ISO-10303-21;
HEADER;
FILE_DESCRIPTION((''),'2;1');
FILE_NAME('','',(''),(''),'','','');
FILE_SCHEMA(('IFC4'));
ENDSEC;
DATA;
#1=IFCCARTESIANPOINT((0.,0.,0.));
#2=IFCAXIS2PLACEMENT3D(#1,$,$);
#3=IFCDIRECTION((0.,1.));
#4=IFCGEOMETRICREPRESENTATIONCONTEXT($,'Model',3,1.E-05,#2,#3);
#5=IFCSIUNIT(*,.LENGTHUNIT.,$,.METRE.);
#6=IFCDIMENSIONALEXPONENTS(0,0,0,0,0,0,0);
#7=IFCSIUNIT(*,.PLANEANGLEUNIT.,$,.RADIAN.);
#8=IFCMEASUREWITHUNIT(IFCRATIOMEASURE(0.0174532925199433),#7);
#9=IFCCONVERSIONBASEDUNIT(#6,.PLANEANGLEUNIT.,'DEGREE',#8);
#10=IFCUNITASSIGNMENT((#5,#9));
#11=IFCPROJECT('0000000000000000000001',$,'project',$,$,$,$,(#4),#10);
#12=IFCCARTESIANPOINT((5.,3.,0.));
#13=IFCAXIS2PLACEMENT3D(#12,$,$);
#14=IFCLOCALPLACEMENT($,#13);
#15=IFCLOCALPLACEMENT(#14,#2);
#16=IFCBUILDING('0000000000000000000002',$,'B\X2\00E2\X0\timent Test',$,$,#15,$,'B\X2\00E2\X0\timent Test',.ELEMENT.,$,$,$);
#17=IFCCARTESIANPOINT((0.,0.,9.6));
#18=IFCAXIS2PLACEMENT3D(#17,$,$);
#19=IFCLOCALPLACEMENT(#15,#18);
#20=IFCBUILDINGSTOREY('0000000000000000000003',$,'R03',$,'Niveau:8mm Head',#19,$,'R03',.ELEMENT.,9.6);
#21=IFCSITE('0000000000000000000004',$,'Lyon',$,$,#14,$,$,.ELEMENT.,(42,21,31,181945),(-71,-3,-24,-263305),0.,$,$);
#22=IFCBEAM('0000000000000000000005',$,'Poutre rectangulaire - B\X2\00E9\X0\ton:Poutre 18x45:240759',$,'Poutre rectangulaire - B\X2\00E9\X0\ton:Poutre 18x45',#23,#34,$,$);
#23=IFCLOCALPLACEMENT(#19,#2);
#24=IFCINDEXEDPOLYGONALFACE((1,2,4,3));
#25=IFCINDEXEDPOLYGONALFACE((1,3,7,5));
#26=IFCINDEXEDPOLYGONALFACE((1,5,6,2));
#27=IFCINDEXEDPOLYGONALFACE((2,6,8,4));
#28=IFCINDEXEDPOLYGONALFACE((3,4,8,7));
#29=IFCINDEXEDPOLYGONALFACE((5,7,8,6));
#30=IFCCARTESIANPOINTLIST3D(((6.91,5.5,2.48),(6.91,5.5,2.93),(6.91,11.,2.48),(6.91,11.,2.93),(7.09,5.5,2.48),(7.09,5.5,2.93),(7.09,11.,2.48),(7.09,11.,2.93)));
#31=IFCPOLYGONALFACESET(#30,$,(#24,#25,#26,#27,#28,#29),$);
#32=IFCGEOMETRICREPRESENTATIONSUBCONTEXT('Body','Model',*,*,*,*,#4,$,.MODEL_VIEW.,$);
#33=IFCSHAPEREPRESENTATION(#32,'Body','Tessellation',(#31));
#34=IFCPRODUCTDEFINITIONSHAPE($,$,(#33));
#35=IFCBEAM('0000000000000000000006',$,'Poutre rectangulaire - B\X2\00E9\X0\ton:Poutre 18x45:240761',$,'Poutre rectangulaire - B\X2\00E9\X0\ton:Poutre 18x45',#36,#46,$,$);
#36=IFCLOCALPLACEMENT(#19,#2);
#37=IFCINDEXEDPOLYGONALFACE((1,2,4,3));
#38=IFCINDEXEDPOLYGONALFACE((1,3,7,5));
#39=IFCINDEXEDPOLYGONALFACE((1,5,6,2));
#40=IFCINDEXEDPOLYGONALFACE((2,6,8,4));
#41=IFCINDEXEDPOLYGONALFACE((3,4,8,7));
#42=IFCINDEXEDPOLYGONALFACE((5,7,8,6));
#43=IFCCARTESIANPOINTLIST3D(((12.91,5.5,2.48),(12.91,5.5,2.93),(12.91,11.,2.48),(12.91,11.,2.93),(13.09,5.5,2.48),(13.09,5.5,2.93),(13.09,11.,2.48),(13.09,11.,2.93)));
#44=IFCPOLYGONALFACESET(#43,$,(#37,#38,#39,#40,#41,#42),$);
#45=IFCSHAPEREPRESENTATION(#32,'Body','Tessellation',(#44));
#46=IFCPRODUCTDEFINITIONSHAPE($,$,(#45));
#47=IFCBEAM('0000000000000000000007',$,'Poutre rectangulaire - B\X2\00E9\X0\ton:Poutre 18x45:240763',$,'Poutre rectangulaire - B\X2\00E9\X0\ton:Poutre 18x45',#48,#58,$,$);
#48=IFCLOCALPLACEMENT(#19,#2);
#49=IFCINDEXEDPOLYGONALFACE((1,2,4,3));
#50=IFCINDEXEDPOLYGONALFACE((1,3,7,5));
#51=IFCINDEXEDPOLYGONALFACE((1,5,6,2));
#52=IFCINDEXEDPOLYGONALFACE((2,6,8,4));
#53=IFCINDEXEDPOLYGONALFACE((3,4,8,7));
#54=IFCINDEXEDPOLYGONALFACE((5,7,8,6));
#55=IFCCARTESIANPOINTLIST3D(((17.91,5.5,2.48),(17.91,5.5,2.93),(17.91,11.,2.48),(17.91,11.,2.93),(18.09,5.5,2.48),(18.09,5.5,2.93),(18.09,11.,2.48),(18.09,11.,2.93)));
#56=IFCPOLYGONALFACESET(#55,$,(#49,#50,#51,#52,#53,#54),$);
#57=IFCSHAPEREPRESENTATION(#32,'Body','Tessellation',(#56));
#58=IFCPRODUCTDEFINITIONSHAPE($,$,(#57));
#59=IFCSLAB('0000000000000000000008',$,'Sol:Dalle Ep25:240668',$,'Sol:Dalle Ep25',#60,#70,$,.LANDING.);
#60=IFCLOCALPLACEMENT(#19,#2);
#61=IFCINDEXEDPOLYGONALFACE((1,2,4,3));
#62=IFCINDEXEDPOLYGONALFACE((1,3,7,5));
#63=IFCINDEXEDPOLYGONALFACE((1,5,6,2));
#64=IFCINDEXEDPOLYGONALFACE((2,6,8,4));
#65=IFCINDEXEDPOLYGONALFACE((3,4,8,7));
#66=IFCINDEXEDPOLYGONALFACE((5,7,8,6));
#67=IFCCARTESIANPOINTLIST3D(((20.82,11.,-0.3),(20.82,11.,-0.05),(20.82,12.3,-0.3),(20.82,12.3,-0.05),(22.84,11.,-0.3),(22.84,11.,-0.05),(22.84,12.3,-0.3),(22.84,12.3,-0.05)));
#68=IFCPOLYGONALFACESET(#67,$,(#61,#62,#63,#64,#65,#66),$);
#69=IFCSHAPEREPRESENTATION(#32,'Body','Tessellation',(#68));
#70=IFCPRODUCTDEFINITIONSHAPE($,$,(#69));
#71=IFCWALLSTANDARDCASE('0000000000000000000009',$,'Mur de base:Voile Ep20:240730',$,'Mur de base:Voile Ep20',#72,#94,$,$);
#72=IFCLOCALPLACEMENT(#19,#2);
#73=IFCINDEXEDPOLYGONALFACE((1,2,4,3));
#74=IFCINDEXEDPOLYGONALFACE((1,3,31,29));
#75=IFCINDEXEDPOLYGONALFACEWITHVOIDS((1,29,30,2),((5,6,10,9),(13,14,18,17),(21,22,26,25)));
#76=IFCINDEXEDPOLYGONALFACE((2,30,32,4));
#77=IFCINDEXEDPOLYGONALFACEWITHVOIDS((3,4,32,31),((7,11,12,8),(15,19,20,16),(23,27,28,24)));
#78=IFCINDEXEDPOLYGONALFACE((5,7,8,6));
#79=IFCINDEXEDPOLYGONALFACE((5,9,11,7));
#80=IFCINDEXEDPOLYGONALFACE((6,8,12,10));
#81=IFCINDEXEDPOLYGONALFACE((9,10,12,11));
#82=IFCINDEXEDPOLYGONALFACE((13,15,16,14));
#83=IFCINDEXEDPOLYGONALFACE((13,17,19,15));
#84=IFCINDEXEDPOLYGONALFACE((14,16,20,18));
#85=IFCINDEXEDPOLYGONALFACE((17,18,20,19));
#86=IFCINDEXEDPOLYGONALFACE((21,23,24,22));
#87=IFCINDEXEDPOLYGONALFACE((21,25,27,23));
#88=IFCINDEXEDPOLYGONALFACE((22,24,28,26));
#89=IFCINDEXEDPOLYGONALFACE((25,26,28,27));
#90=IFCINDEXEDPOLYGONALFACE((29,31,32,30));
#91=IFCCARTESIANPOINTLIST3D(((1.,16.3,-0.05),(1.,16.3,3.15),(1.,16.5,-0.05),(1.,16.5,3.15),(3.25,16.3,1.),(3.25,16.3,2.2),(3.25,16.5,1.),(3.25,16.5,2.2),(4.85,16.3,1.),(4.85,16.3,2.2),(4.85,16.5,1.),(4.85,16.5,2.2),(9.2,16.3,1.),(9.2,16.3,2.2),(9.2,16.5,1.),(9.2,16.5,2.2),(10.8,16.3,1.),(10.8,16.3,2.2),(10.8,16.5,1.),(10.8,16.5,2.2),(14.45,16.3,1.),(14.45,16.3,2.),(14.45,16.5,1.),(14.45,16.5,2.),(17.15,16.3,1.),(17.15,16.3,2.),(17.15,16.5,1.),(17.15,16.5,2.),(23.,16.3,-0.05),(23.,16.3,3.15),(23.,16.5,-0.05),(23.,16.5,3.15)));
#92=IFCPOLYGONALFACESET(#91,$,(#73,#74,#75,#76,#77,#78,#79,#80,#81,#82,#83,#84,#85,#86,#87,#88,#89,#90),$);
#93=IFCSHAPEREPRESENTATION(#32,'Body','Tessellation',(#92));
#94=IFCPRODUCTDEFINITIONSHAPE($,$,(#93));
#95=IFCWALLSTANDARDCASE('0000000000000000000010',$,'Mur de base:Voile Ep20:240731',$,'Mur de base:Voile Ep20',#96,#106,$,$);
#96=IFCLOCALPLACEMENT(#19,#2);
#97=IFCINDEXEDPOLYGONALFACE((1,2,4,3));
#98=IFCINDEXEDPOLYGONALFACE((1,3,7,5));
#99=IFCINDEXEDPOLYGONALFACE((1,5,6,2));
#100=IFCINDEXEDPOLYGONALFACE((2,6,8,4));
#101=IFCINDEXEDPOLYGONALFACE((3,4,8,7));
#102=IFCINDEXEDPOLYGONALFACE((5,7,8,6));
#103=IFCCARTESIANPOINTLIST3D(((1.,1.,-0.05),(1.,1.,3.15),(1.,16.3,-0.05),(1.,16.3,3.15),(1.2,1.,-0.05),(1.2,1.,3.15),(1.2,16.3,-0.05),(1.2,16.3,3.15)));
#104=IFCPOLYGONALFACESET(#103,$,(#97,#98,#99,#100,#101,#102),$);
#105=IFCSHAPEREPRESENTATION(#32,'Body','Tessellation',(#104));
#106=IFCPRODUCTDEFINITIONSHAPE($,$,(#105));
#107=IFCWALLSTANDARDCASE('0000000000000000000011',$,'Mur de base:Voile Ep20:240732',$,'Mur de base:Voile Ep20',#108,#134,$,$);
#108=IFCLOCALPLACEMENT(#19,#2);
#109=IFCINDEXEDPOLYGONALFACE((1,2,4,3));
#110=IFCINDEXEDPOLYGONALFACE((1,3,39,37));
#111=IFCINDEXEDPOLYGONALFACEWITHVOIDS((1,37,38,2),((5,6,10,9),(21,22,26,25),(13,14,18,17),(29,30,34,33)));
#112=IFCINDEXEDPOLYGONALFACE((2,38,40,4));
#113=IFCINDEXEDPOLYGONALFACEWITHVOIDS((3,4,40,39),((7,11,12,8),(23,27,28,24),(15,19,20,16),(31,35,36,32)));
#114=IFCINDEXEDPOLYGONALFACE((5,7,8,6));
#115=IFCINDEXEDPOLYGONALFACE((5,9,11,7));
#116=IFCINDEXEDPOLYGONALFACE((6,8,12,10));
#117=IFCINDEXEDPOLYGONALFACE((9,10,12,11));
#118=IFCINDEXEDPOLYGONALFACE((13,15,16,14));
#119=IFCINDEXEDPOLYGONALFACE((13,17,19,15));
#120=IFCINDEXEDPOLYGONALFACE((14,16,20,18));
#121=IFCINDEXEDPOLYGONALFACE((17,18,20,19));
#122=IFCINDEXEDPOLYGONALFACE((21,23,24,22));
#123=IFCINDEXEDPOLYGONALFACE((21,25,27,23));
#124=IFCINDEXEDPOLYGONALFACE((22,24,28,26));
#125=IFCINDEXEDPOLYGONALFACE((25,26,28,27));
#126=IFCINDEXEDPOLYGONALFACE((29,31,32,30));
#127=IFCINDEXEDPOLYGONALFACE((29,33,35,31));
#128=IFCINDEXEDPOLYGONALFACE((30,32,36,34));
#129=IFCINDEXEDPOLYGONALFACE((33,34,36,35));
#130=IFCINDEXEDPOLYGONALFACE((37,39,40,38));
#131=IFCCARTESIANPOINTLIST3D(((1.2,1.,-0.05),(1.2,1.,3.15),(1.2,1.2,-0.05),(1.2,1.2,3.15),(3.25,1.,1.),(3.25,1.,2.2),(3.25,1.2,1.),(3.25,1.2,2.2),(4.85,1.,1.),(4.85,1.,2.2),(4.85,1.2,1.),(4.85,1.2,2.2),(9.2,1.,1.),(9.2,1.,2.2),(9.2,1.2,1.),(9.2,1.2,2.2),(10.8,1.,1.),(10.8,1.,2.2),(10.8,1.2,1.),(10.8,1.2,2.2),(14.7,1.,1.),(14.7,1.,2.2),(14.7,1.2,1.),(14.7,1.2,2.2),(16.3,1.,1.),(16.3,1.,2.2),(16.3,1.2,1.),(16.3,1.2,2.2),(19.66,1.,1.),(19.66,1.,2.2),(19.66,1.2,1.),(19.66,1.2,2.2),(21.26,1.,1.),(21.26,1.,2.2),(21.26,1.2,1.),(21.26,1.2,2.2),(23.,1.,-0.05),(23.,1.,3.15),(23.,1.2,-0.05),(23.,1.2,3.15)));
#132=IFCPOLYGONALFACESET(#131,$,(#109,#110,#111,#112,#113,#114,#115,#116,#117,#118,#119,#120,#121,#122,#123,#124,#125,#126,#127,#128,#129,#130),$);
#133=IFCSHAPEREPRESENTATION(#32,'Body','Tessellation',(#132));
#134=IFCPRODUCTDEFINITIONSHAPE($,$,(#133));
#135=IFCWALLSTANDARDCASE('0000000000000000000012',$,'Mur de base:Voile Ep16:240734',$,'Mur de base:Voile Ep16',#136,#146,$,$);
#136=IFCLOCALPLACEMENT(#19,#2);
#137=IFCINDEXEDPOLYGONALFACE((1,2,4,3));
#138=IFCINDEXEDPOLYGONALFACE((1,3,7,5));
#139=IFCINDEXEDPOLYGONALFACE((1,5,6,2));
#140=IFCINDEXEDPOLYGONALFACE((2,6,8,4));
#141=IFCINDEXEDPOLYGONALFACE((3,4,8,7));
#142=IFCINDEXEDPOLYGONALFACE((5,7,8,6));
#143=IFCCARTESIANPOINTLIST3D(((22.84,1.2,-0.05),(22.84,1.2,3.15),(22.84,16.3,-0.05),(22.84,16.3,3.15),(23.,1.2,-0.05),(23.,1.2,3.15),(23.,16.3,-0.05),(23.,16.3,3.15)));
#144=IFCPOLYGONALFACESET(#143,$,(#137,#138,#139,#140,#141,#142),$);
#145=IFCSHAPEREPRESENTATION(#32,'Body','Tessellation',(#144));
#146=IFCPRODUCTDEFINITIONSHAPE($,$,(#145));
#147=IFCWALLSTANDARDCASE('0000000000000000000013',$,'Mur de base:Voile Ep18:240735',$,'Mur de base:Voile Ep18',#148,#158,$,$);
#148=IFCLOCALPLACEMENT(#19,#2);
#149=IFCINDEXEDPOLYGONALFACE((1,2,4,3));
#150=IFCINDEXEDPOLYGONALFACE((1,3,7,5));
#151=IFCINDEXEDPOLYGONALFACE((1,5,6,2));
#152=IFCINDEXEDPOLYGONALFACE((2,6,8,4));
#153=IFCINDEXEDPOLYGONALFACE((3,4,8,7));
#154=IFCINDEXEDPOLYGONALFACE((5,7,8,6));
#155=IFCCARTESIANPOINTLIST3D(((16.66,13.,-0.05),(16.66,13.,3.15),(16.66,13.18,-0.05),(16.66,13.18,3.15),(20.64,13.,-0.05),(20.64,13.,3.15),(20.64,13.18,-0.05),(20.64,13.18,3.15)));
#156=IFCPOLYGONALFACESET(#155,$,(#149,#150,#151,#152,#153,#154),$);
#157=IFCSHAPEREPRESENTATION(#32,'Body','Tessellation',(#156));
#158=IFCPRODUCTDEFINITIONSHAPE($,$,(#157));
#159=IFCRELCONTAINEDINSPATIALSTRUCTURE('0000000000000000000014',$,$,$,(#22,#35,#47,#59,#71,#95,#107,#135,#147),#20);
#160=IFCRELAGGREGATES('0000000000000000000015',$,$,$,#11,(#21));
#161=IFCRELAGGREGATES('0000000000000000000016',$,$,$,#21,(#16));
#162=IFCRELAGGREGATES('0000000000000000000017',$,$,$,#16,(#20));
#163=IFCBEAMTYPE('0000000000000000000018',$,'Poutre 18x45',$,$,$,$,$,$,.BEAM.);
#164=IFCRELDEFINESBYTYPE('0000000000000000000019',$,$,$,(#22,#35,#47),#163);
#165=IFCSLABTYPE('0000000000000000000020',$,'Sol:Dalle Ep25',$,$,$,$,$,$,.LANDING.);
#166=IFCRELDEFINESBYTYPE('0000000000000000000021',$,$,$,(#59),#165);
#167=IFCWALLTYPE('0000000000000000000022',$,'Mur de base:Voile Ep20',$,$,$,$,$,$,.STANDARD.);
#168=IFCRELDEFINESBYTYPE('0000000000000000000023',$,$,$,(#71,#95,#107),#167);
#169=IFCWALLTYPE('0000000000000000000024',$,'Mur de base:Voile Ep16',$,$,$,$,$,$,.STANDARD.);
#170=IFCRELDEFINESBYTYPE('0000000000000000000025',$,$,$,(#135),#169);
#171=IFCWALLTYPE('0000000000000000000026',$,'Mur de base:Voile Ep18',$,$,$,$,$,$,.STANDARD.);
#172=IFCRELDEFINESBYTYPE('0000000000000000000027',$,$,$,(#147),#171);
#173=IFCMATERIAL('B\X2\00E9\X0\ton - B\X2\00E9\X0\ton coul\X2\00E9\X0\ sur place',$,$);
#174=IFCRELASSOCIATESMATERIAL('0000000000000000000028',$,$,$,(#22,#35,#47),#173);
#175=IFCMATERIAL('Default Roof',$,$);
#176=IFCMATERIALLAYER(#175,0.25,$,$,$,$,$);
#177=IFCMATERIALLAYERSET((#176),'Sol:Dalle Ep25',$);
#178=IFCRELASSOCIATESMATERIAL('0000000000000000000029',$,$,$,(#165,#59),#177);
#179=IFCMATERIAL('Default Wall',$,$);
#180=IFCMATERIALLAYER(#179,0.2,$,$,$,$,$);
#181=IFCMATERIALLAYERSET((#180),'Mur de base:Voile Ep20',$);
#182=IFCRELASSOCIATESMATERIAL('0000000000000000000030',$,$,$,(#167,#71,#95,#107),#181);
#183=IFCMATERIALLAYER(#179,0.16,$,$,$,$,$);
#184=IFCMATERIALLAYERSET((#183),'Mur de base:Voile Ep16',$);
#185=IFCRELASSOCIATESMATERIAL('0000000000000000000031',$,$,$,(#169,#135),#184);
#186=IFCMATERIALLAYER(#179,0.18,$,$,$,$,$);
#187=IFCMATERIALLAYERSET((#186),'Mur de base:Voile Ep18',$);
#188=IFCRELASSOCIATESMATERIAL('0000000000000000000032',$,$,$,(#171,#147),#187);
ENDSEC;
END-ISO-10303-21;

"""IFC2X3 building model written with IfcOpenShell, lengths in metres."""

from ifc_helpers import new_model, entity, si_unit, converted_unit, direction, frame, frame_2d, origin, origin_2d_with_axis, place, context, subcontext, project, spatial, rectangle, extrude, material, layer, layer_set, layer_usage, type_object, element, save


model = new_model("IFC2X3")

# Units and contexts
model_context = context("Model", 3, precision=1e-05, world=origin(), true_north=direction((0.0, 1.0)))
body_context = subcontext(model_context, "Body", "Model", "MODEL_VIEW")
ifc_project = project(units=[si_unit("LENGTHUNIT", "METRE"), converted_unit("PLANEANGLEUNIT", "DEGREE", entity("IfcRatioMeasure", 0.0174532925199433), si_unit("PLANEANGLEUNIT", "RADIAN"), dimensions=[0, 0, 0, 0, 0, 0, 0])], contexts=[model_context])

# Site, building, storey
site_placement = place(None, frame((5.0, 3.0, 0.0)))
site = spatial("IfcSite", under=ifc_project, at=site_placement, Name="Lyon", CompositionType="ELEMENT", RefLatitude=(42, 21, 31, 181945), RefLongitude=(-71, -3, -24, -263305), RefElevation=0.0)
building_placement = place(site_placement, origin())
building = spatial("IfcBuilding", under=site, at=building_placement, Name="Bâtiment Test", LongName="Bâtiment Test", CompositionType="ELEMENT")
storey_placement = place(building_placement, frame((0.0, 0.0, 9.6)))
storey = spatial("IfcBuildingStorey", under=building, at=storey_placement, Name="R03", ObjectType="Niveau:8mm Head", LongName="R03", CompositionType="ELEMENT", Elevation=9.6)

# Beams
ifc_material_1 = material(Name="Béton - Béton coulé sur place")
beam_type = type_object("IfcBeamType", Name="Poutre 18x45", PredefinedType="BEAM")
beam_1_placement = place(storey_placement, frame((7.0, 11.0, 2.93), z_axis=(0.0, 0.0, 1.0), x_axis=(0.0, -1.0, 0.0)))
element("IfcBeam", 1, at=beam_1_placement, inside=storey, type_object=beam_type, material=ifc_material_1, Name="Poutre rectangulaire - Béton:Poutre 18x45:240759", ObjectType="Poutre rectangulaire - Béton:Poutre 18x45", context=body_context, shape_type="SweptSolid", body=[
    extrude(rectangle(XDim=0.45, YDim=0.18, at=frame_2d((0.0, 0.0), x_axis=(1.0, 0.0))), frame((0.0, 0.0, -0.225), z_axis=(1.0, 0.0, 0.0), x_axis=(0.0, 0.0, -1.0)), (0.0, 0.0, 1.0), 5.5),
])
beam_2_placement = place(storey_placement, frame((13.0, 11.0, 2.93), z_axis=(0.0, 0.0, 1.0), x_axis=(0.0, -1.0, 0.0)))
element("IfcBeam", 2, at=beam_2_placement, inside=storey, type_object=beam_type, material=ifc_material_1, Name="Poutre rectangulaire - Béton:Poutre 18x45:240761", ObjectType="Poutre rectangulaire - Béton:Poutre 18x45", context=body_context, shape_type="SweptSolid", body=[
    extrude(rectangle(XDim=0.45, YDim=0.18, at=frame_2d((0.0, 0.0), x_axis=(1.0, 0.0))), frame((0.0, 0.0, -0.225), z_axis=(1.0, 0.0, 0.0), x_axis=(0.0, 0.0, -1.0)), (0.0, 0.0, 1.0), 5.5),
])
beam_3_placement = place(storey_placement, frame((18.0, 5.5, 2.93), z_axis=(0.0, 0.0, 1.0), x_axis=(0.0, 1.0, 0.0)))
element("IfcBeam", 3, at=beam_3_placement, inside=storey, type_object=beam_type, material=ifc_material_1, Name="Poutre rectangulaire - Béton:Poutre 18x45:240763", ObjectType="Poutre rectangulaire - Béton:Poutre 18x45", context=body_context, shape_type="SweptSolid", body=[
    extrude(rectangle(XDim=0.45, YDim=0.18, at=frame_2d((0.0, 0.0), x_axis=(1.0, 0.0))), frame((0.0, 0.0, -0.225), z_axis=(1.0, 0.0, 0.0), x_axis=(0.0, 0.0, -1.0)), (0.0, 0.0, 1.0), 5.5),
])

# Slab
ifc_material_2 = material(Name="Default Roof")
ifc_layer_1 = layer(ifc_material_2, 0.25)
ifc_layer_set_1 = layer_set([ifc_layer_1], Name="Sol:Dalle Ep25")
ifc_layer_usage_1 = layer_usage(ifc_layer_set_1, "AXIS3", "POSITIVE", 0.0)
slab_type_1 = type_object("IfcSlabType", Name="Sol:Dalle Ep25", PredefinedType="LANDING", material=ifc_layer_set_1)
slab_1_placement = place(storey_placement, origin())
element("IfcSlab", 4, at=slab_1_placement, inside=storey, type_object=slab_type_1, material=ifc_layer_usage_1, Name="Sol:Dalle Ep25:240668", ObjectType="Sol:Dalle Ep25", PredefinedType="LANDING", context=body_context, shape_type="SweptSolid", body=[
    extrude(rectangle(XDim=1.3, YDim=2.02, at=frame_2d((0.0, 0.0), x_axis=(1.0, 0.0))), frame((21.83, 11.65, -0.05), z_axis=(0.0, 0.0, -1.0), x_axis=(0.0, 1.0, 0.0)), (0.0, 0.0, 1.0), 0.25),
])

# Wall, openings
ifc_material_3 = material(Name="Default Wall")
ifc_layer_2 = layer(ifc_material_3, 0.2)
ifc_layer_set_2 = layer_set([ifc_layer_2], Name="Mur de base:Voile Ep20")
ifc_layer_usage_2 = layer_usage(ifc_layer_set_2, "AXIS2", "POSITIVE", -0.1)
wall_type_1 = type_object("IfcWallType", Name="Mur de base:Voile Ep20", PredefinedType="STANDARD", material=ifc_layer_set_2)
wall_1_placement = place(storey_placement, frame((23.0, 16.4, -0.05), z_axis=(0.0, 0.0, 1.0), x_axis=(-1.0, 0.0, 0.0)))
wall_1 = element("IfcWallStandardCase", 5, at=wall_1_placement, inside=storey, type_object=wall_type_1, material=ifc_layer_usage_2, Name="Mur de base:Voile Ep20:240730", ObjectType="Mur de base:Voile Ep20", context=body_context, shape_type="SweptSolid", body=[
    extrude(rectangle(XDim=22.0, YDim=0.2, at=frame_2d((11.0, 0.0), x_axis=(-1.0, 0.0))), origin(), (0.0, 0.0, 1.0), 3.2),
])
opening_1_placement = place(wall_1_placement, origin())
element("IfcOpeningElement", 6, at=opening_1_placement, cuts=wall_1, ObjectType="Opening", context=body_context, shape_type="SweptSolid", body=[
    extrude(rectangle(XDim=1.0, YDim=2.7, at=origin_2d_with_axis()), frame((7.2, -0.1, 1.55), z_axis=(0.0, 1.0, 0.0), x_axis=(0.0, 0.0, -1.0)), (0.0, 0.0, 1.0), 0.2),
])
opening_2_placement = place(wall_1_placement, origin())
element("IfcOpeningElement", 7, at=opening_2_placement, cuts=wall_1, ObjectType="Opening", context=body_context, shape_type="SweptSolid", body=[
    extrude(rectangle(XDim=1.2, YDim=1.6, at=frame_2d((0.0, 0.0), x_axis=(1.0, 0.0))), frame((13.0, -0.1, 1.65), z_axis=(0.0, 1.0, 0.0), x_axis=(0.0, 0.0, -1.0)), (0.0, 0.0, 1.0), 0.2),
])
opening_3_placement = place(wall_1_placement, origin())
element("IfcOpeningElement", 8, at=opening_3_placement, cuts=wall_1, ObjectType="Opening", context=body_context, shape_type="SweptSolid", body=[
    extrude(rectangle(XDim=1.2, YDim=1.6, at=frame_2d((0.0, 0.0), x_axis=(1.0, 0.0))), frame((18.95, -0.1, 1.65), z_axis=(0.0, 1.0, 0.0), x_axis=(0.0, 0.0, -1.0)), (0.0, 0.0, 1.0), 0.2),
])

# Wall
ifc_layer_usage_3 = layer_usage(ifc_layer_set_2, "AXIS2", "POSITIVE", -0.1)
wall_2_placement = place(storey_placement, frame((1.1, 16.3, -0.05), z_axis=(0.0, 0.0, 1.0), x_axis=(0.0, -1.0, 0.0)))
element("IfcWallStandardCase", 9, at=wall_2_placement, inside=storey, type_object=wall_type_1, material=ifc_layer_usage_3, Name="Mur de base:Voile Ep20:240731", ObjectType="Mur de base:Voile Ep20", context=body_context, shape_type="SweptSolid", body=[
    extrude(rectangle(XDim=15.3, YDim=0.2, at=frame_2d((7.65, 0.0), x_axis=(-1.0, 0.0))), origin(), (0.0, 0.0, 1.0), 3.2),
])

# Wall, openings
ifc_layer_usage_4 = layer_usage(ifc_layer_set_2, "AXIS2", "POSITIVE", -0.1)
wall_3_placement = place(storey_placement, frame((1.2, 1.1, -0.05)))
wall_3 = element("IfcWallStandardCase", 10, at=wall_3_placement, inside=storey, type_object=wall_type_1, material=ifc_layer_usage_4, Name="Mur de base:Voile Ep20:240732", ObjectType="Mur de base:Voile Ep20", context=body_context, shape_type="SweptSolid", body=[
    extrude(rectangle(XDim=21.8, YDim=0.2, at=frame_2d((10.9, 0.0), x_axis=(-1.0, 0.0))), origin(), (0.0, 0.0, 1.0), 3.2),
])
opening_4_placement = place(wall_3_placement, origin())
element("IfcOpeningElement", 11, at=opening_4_placement, cuts=wall_3, ObjectType="Opening", context=body_context, shape_type="SweptSolid", body=[
    extrude(rectangle(XDim=1.2, YDim=1.6, at=frame_2d((0.0, 0.0), x_axis=(0.0, 1.0))), frame((2.85, -0.1, 1.65), z_axis=(0.0, 1.0, 0.0), x_axis=(1.0, 0.0, 0.0)), (0.0, 0.0, 1.0), 0.2),
])
opening_5_placement = place(wall_3_placement, origin())
element("IfcOpeningElement", 12, at=opening_5_placement, cuts=wall_3, ObjectType="Opening", context=body_context, shape_type="SweptSolid", body=[
    extrude(rectangle(XDim=1.2, YDim=1.6, at=frame_2d((0.0, 0.0), x_axis=(1.0, 0.0))), frame((8.8, -0.1, 1.65), z_axis=(0.0, 1.0, 0.0), x_axis=(0.0, 0.0, -1.0)), (0.0, 0.0, 1.0), 0.2),
])
opening_6_placement = place(wall_3_placement, origin())
element("IfcOpeningElement", 13, at=opening_6_placement, cuts=wall_3, ObjectType="Opening", context=body_context, shape_type="SweptSolid", body=[
    extrude(rectangle(XDim=1.2, YDim=1.6, at=frame_2d((0.0, 0.0), x_axis=(0.0, 1.0))), frame((14.3, -0.1, 1.65), z_axis=(0.0, 1.0, 0.0), x_axis=(1.0, 0.0, 0.0)), (0.0, 0.0, 1.0), 0.2),
])
opening_7_placement = place(wall_3_placement, origin())
element("IfcOpeningElement", 14, at=opening_7_placement, cuts=wall_3, ObjectType="Opening", context=body_context, shape_type="SweptSolid", body=[
    extrude(rectangle(XDim=1.2, YDim=1.6, at=frame_2d((0.0, 0.0), x_axis=(1.0, 0.0))), frame((19.26, -0.1, 1.65), z_axis=(0.0, 1.0, 0.0), x_axis=(0.0, 0.0, -1.0)), (0.0, 0.0, 1.0), 0.2),
])

# Walls
ifc_layer_3 = layer(ifc_material_3, 0.16)
ifc_layer_set_3 = layer_set([ifc_layer_3], Name="Mur de base:Voile Ep16")
ifc_layer_usage_5 = layer_usage(ifc_layer_set_3, "AXIS2", "NEGATIVE", 0.08)
wall_type_2 = type_object("IfcWallType", Name="Mur de base:Voile Ep16", PredefinedType="STANDARD", material=ifc_layer_set_3)
wall_4_placement = place(storey_placement, frame((22.92, 16.3, -0.05), z_axis=(0.0, 0.0, 1.0), x_axis=(0.0, -1.0, 0.0)))
element("IfcWallStandardCase", 15, at=wall_4_placement, inside=storey, type_object=wall_type_2, material=ifc_layer_usage_5, Name="Mur de base:Voile Ep16:240734", ObjectType="Mur de base:Voile Ep16", context=body_context, shape_type="SweptSolid", body=[
    extrude(rectangle(XDim=15.1, YDim=0.16, at=frame_2d((7.55, 0.0), x_axis=(-1.0, 0.0))), origin(), (0.0, 0.0, 1.0), 3.2),
])
ifc_layer_4 = layer(ifc_material_3, 0.18)
ifc_layer_set_4 = layer_set([ifc_layer_4], Name="Mur de base:Voile Ep18")
ifc_layer_usage_6 = layer_usage(ifc_layer_set_4, "AXIS2", "NEGATIVE", 0.09)
wall_type_3 = type_object("IfcWallType", Name="Mur de base:Voile Ep18", PredefinedType="STANDARD", material=ifc_layer_set_4)
wall_5_placement = place(storey_placement, frame((20.64, 13.09, -0.05), z_axis=(0.0, 0.0, 1.0), x_axis=(-1.0, 0.0, 0.0)))
element("IfcWallStandardCase", 16, at=wall_5_placement, inside=storey, type_object=wall_type_3, material=ifc_layer_usage_6, Name="Mur de base:Voile Ep18:240735", ObjectType="Mur de base:Voile Ep18", context=body_context, shape_type="SweptSolid", body=[
    extrude(rectangle(XDim=3.98, YDim=0.18, at=frame_2d((1.99, 0.0), x_axis=(-1.0, 0.0))), origin(), (0.0, 0.0, 1.0), 3.2),
])

save(model, "model.ifc")
